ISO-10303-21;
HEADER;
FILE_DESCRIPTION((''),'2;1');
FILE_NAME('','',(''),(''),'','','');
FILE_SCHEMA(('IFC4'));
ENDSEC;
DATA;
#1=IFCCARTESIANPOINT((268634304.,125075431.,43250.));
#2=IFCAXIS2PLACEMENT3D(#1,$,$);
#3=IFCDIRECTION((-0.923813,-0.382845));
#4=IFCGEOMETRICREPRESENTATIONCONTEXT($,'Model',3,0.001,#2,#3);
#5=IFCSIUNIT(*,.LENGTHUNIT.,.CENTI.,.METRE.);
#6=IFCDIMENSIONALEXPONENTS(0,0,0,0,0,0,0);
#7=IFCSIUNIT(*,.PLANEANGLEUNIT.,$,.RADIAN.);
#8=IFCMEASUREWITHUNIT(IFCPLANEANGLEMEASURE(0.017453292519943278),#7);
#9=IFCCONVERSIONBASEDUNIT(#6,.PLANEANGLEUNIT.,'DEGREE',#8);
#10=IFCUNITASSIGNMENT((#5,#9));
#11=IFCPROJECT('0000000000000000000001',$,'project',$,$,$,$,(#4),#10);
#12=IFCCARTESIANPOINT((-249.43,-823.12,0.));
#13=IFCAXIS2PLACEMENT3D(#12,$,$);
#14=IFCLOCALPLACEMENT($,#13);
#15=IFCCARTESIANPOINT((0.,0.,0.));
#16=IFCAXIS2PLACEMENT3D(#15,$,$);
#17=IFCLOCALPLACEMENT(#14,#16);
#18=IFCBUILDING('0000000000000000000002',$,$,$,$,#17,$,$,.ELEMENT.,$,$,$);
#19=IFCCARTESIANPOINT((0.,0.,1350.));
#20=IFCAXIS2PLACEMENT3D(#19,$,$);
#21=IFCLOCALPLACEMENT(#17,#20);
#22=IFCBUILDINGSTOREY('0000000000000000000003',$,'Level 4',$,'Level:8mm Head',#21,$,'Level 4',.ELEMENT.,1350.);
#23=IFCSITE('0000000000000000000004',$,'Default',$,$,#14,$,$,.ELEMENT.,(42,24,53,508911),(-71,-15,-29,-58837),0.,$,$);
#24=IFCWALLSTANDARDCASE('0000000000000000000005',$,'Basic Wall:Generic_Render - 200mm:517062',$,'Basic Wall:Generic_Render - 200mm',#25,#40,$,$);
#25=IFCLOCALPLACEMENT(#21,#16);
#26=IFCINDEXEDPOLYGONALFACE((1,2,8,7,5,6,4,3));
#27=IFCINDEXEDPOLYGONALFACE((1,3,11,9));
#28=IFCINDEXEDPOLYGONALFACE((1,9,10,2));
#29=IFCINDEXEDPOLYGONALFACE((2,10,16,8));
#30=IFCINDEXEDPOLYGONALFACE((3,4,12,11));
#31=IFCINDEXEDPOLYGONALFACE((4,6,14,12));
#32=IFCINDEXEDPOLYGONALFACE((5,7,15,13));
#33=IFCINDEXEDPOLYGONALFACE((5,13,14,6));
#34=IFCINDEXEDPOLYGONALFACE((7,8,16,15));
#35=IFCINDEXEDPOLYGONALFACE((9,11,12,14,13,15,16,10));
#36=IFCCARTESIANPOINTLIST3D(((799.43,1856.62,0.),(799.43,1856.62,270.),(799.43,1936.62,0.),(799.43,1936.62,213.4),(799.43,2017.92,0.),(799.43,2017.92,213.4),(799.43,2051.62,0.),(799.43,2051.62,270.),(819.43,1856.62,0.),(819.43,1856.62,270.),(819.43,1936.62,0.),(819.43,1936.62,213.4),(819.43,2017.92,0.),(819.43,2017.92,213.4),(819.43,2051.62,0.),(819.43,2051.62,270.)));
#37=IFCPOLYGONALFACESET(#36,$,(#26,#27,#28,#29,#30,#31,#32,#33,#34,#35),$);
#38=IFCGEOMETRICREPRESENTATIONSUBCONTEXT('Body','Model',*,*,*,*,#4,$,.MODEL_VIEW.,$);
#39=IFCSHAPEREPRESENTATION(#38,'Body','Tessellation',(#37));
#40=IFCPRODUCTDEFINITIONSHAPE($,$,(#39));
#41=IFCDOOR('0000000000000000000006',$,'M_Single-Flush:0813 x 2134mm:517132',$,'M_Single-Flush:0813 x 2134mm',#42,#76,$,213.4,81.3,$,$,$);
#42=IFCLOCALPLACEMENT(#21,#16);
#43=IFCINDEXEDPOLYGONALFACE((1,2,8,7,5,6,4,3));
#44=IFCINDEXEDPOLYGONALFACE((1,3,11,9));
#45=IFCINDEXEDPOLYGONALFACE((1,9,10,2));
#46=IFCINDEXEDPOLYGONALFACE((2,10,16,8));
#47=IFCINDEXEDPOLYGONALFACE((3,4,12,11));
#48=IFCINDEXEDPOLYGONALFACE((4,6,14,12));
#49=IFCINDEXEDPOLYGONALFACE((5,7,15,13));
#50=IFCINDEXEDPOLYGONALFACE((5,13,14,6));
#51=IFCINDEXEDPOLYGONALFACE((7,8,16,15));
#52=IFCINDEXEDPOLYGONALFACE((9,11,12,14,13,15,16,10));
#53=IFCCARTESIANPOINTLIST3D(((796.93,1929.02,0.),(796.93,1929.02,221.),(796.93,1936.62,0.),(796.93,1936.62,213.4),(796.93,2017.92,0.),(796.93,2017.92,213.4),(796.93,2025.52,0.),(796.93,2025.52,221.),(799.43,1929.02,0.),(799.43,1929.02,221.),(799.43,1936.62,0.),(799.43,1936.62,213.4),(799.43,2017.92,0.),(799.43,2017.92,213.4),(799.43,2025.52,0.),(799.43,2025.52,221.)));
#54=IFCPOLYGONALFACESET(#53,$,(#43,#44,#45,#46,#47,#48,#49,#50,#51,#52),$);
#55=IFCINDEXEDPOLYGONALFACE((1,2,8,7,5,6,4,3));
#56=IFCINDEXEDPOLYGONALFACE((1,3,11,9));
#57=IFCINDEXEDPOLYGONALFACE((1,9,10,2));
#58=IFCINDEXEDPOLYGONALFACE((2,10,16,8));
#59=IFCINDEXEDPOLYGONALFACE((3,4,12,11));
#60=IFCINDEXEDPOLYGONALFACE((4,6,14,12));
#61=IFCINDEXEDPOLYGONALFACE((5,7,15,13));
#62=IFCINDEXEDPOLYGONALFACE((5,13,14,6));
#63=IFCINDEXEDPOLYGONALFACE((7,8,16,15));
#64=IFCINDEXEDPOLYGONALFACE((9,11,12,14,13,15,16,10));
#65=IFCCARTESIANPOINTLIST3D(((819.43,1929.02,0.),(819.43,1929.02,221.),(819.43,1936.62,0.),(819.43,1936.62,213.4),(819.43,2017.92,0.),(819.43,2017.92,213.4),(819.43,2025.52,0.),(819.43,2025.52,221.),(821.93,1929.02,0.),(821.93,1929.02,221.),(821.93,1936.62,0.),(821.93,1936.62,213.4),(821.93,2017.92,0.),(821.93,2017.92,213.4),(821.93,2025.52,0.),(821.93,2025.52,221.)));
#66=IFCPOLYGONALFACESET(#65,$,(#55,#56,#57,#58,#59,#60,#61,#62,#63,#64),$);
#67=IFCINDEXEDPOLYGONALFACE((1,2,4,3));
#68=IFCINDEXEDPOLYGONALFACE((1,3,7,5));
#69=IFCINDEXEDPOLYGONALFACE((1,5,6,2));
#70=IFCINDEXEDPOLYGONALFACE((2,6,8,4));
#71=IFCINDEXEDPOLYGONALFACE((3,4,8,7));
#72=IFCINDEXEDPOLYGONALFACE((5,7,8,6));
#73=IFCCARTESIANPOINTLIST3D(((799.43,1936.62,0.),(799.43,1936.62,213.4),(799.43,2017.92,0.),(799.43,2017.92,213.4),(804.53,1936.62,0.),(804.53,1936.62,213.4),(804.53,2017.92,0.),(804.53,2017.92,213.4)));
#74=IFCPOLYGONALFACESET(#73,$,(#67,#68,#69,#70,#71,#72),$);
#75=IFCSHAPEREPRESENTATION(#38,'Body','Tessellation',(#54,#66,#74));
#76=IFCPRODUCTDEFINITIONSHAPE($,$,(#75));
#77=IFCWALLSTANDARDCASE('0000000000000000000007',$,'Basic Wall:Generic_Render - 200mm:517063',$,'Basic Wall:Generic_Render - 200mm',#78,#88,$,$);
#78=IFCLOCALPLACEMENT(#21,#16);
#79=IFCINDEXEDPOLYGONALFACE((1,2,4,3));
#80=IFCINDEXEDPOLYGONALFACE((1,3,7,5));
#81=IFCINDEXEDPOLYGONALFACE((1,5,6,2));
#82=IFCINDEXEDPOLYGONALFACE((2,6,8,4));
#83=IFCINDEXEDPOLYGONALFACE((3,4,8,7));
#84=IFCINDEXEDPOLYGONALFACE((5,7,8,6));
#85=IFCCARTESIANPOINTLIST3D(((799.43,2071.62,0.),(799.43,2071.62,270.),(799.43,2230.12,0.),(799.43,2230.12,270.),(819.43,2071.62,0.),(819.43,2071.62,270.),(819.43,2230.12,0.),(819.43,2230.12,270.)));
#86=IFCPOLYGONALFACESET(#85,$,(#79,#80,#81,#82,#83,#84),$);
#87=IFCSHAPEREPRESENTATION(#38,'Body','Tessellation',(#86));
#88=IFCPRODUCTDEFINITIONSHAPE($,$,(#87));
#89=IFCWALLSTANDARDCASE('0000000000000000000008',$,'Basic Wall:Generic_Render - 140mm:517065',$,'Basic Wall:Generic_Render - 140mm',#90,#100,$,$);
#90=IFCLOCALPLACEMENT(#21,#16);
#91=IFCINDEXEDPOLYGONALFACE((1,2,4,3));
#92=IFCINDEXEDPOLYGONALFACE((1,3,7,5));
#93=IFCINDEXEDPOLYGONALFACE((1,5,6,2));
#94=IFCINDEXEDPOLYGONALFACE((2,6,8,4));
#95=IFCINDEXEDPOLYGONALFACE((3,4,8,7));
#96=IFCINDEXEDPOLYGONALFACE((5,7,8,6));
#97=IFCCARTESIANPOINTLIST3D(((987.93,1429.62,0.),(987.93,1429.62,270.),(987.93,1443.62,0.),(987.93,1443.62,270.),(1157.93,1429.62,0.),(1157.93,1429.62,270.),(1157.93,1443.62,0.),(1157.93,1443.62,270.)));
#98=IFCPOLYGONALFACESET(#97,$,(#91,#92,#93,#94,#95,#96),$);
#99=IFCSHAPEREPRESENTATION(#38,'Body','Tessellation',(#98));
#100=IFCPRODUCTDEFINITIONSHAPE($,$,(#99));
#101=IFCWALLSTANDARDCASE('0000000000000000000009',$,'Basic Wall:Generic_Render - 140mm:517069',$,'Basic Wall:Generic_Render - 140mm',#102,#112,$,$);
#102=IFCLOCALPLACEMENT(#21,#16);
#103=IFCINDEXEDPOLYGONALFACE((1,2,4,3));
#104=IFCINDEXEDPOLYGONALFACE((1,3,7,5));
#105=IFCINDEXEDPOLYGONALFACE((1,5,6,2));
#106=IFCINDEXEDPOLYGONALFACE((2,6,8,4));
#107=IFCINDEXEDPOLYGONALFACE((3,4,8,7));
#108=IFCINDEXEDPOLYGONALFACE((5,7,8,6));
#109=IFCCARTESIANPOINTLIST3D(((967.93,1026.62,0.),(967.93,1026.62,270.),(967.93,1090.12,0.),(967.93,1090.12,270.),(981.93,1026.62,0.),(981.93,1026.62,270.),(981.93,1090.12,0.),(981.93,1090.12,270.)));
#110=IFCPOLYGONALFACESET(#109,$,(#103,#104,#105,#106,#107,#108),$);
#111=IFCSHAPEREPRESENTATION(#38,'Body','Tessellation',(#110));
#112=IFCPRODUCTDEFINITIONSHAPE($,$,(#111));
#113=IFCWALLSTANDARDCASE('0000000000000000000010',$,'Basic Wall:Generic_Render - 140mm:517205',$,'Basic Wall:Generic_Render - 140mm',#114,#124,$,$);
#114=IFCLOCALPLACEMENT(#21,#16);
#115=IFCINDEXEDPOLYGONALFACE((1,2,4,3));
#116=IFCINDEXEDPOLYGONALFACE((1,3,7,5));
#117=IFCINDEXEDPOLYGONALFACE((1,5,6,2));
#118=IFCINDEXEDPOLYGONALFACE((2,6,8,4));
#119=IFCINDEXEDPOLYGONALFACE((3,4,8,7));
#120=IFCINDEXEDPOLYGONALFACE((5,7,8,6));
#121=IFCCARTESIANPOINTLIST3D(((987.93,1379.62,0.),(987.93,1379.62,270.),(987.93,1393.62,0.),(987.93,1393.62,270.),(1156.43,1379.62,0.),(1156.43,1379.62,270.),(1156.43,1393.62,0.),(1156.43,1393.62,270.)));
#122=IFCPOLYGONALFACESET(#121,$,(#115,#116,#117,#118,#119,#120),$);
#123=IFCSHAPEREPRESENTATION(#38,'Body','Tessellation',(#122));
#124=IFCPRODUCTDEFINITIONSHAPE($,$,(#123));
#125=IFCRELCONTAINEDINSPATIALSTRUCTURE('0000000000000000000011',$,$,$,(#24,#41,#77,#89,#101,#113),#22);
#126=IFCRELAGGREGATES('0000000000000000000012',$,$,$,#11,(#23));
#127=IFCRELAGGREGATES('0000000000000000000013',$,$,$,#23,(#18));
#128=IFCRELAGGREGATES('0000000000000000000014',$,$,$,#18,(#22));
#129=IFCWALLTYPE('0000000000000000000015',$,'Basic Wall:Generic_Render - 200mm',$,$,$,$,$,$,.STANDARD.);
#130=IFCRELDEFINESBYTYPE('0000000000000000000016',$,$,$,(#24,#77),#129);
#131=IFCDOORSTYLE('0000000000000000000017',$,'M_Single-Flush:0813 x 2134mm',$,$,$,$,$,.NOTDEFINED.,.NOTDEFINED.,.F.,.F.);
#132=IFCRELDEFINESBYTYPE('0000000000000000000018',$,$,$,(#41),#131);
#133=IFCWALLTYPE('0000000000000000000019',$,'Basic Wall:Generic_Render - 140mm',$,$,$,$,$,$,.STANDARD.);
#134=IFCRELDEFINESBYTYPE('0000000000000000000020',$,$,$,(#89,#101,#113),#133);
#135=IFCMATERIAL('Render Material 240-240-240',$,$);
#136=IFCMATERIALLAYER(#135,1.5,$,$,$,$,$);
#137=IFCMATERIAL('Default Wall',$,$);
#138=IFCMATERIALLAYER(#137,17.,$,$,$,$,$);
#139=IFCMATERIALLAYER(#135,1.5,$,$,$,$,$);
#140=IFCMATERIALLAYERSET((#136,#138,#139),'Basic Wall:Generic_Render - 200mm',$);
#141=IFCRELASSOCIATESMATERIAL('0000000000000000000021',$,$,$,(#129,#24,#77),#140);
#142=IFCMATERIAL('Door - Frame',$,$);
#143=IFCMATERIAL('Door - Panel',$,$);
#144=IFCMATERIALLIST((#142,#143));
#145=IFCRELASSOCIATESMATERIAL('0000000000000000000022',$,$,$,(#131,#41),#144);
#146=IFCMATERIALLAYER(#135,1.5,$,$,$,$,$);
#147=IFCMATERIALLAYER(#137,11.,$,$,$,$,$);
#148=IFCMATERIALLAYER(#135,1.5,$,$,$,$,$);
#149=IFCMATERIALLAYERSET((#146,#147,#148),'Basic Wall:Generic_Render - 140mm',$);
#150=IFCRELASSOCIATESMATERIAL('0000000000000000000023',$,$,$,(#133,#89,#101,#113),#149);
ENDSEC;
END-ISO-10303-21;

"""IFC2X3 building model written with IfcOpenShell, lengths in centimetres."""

from ifc_helpers import new_model, entity, si_unit, converted_unit, direction, frame, frame_2d, origin, place, context, subcontext, project, spatial, polyline, rectangle, outline, extrude, source, transform, mapped, material, material_list, layer, layer_set, layer_usage, type_object, type_shapes, element, fill, save


model = new_model("IFC2X3")

# Units and contexts
model_context = context("Model", 3, precision=0.001, world=frame((268634304.0, 125075431.0, 43250.0)), true_north=direction((-0.923813, -0.382845)))
body_context = subcontext(model_context, "Body", "Model", "MODEL_VIEW")
ifc_project = project(units=[si_unit("LENGTHUNIT", "METRE", prefix="CENTI"), converted_unit("PLANEANGLEUNIT", "DEGREE", entity("IfcPlaneAngleMeasure", 0.017453292519943278), si_unit("PLANEANGLEUNIT", "RADIAN"), dimensions=[0, 0, 0, 0, 0, 0, 0])], contexts=[model_context])

# Site, building, storey
site_placement = place(None, frame((-249.43, -823.12, 0.0)))
site = spatial("IfcSite", under=ifc_project, at=site_placement, Name="Default", CompositionType="ELEMENT", RefLatitude=(42, 24, 53, 508911), RefLongitude=(-71, -15, -29, -58837), RefElevation=0.0)
building_placement = place(site_placement, origin())
building = spatial("IfcBuilding", under=site, at=building_placement, CompositionType="ELEMENT")
storey_placement = place(building_placement, frame((0.0, 0.0, 1350.0)))
storey = spatial("IfcBuildingStorey", under=building, at=storey_placement, Name="Level 4", ObjectType="Level:8mm Head", LongName="Level 4", CompositionType="ELEMENT", Elevation=1350.0)

# Shared definitions
ifc_material_1 = material(Name="Render Material 240-240-240")
ifc_layer_1 = layer(ifc_material_1, 1.5)
ifc_material_2 = material(Name="Default Wall")
ifc_layer_2 = layer(ifc_material_2, 17.0)
ifc_layer_3 = layer(ifc_material_1, 1.5)
ifc_layer_set_1 = layer_set([ifc_layer_1, ifc_layer_2, ifc_layer_3], Name="Basic Wall:Generic_Render - 200mm")
wall_type_1 = type_object("IfcWallType", Name="Basic Wall:Generic_Render - 200mm", PredefinedType="STANDARD", material=ifc_layer_set_1)

# Wall, opening, door
ifc_layer_usage_1 = layer_usage(ifc_layer_set_1, "AXIS2", "NEGATIVE", 10.0)
wall_1_placement = place(storey_placement, frame((809.43, 1856.62, 0.0), z_axis=(0.0, 0.0, 1.0), x_axis=(0.0, 1.0, 0.0)))
wall_1 = element("IfcWallStandardCase", 1, at=wall_1_placement, inside=storey, type_object=wall_type_1, material=ifc_layer_usage_1, Name="Basic Wall:Generic_Render - 200mm:517062", ObjectType="Basic Wall:Generic_Render - 200mm", context=body_context, shape_type="SweptSolid", body=[
    extrude(rectangle(XDim=195.0, YDim=20.0, at=frame_2d((97.5, 0.0), x_axis=(-1.0, 0.0))), origin(), (0.0, 0.0, 1.0), 270.0),
])
opening_1_placement = place(wall_1_placement, frame((80.0, -10.0, 0.0)))
opening_1 = element("IfcOpeningElement", 2, at=opening_1_placement, cuts=wall_1, ObjectType="Opening", context=body_context, shape_type="SweptSolid", body=[
    extrude(rectangle(XDim=81.3, YDim=213.4, at=frame_2d((106.7, 40.65), x_axis=(0.0, 1.0))), frame((0.0, 0.0, 0.0), z_axis=(0.0, 1.0, 0.0), x_axis=(0.0, 0.0, 1.0)), (0.0, 0.0, 1.0), 20.0),
])
ifc_material_3 = material(Name="Door - Frame")
ifc_material_4 = material(Name="Door - Panel")
ifc_material_list_1 = material_list([ifc_material_3, ifc_material_4])
door_style = type_object("IfcDoorStyle", Name="M_Single-Flush:0813 x 2134mm", ConstructionType="NOTDEFINED", OperationType="NOTDEFINED", ParameterTakesPrecedence=False, Sizeable=False, material=ifc_material_list_1)
shared_shape_1 = source(origin(), body_context, "Body", "SweptSolid", [
    extrude(outline(polyline([(-48.25, -112.4), (48.25, -112.4), (48.25, 108.6), (40.65, 108.6), (40.65, -104.8), (-40.65, -104.8), (-40.65, 108.6), (-48.25, 108.6), (-48.25, -112.4)])), frame((40.65, 20.0, 108.6), z_axis=(0.0, 1.0, 0.0), x_axis=(1.0, 0.0, 0.0)), (0.0, 0.0, 1.0), 2.5),
    extrude(outline(polyline([(-112.4, -48.25), (108.6, -48.25), (108.6, -40.65), (-104.8, -40.65), (-104.8, 40.65), (108.6, 40.65), (108.6, 48.25), (-112.4, 48.25), (-112.4, -48.25)])), frame((40.65, -2.5, 108.6), z_axis=(0.0, 1.0, 0.0), x_axis=(0.0, 0.0, -1.0)), (0.0, 0.0, 1.0), 2.5),
    extrude(rectangle(XDim=5.1, YDim=81.3, at=frame_2d((0.0, 0.0), x_axis=(1.0, 0.0))), frame((40.65, 17.45, 0.0), z_axis=(0.0, 0.0, 1.0), x_axis=(0.0, 1.0, 0.0)), (0.0, 0.0, 1.0), 213.4),
])
type_shapes(door_style, [shared_shape_1])
door_placement = place(opening_1_placement, origin())
door = element("IfcDoor", 3, at=door_placement, inside=storey, type_object=door_style, material=ifc_material_list_1, Name="M_Single-Flush:0813 x 2134mm:517132", ObjectType="M_Single-Flush:0813 x 2134mm", OverallHeight=213.4, OverallWidth=81.3, context=body_context, shape_type="MappedRepresentation", body=[
    mapped(shared_shape_1, transform((0.0, 0.0, 0.0), scale=1.0)),
])
fill(opening_1, door)

# Walls
ifc_layer_usage_2 = layer_usage(ifc_layer_set_1, "AXIS2", "NEGATIVE", 10.0)
wall_2_placement = place(storey_placement, frame((809.43, 2071.62, 0.0), z_axis=(0.0, 0.0, 1.0), x_axis=(0.0, 1.0, 0.0)))
element("IfcWallStandardCase", 4, at=wall_2_placement, inside=storey, type_object=wall_type_1, material=ifc_layer_usage_2, Name="Basic Wall:Generic_Render - 200mm:517063", ObjectType="Basic Wall:Generic_Render - 200mm", context=body_context, shape_type="SweptSolid", body=[
    extrude(rectangle(XDim=158.5, YDim=20.0, at=frame_2d((79.25, 0.0), x_axis=(-1.0, 0.0))), origin(), (0.0, 0.0, 1.0), 270.0),
])
ifc_layer_4 = layer(ifc_material_1, 1.5)
ifc_layer_5 = layer(ifc_material_2, 11.0)
ifc_layer_6 = layer(ifc_material_1, 1.5)
ifc_layer_set_2 = layer_set([ifc_layer_4, ifc_layer_5, ifc_layer_6], Name="Basic Wall:Generic_Render - 140mm")
ifc_layer_usage_3 = layer_usage(ifc_layer_set_2, "AXIS2", "NEGATIVE", 7.0)
wall_type_2 = type_object("IfcWallType", Name="Basic Wall:Generic_Render - 140mm", PredefinedType="STANDARD", material=ifc_layer_set_2)
wall_3_placement = place(storey_placement, frame((1157.93, 1436.62, 0.0), z_axis=(0.0, 0.0, 1.0), x_axis=(-1.0, 0.0, 0.0)))
element("IfcWallStandardCase", 5, at=wall_3_placement, inside=storey, type_object=wall_type_2, material=ifc_layer_usage_3, Name="Basic Wall:Generic_Render - 140mm:517065", ObjectType="Basic Wall:Generic_Render - 140mm", context=body_context, shape_type="SweptSolid", body=[
    extrude(rectangle(XDim=170.0, YDim=14.0, at=frame_2d((85.0, 0.0), x_axis=(-1.0, 0.0))), origin(), (0.0, 0.0, 1.0), 270.0),
])
ifc_layer_usage_4 = layer_usage(ifc_layer_set_2, "AXIS2", "NEGATIVE", 7.0)
wall_4_placement = place(storey_placement, frame((974.93, 1090.12, 0.0), z_axis=(0.0, 0.0, 1.0), x_axis=(0.0, -1.0, 0.0)))
element("IfcWallStandardCase", 6, at=wall_4_placement, inside=storey, type_object=wall_type_2, material=ifc_layer_usage_4, Name="Basic Wall:Generic_Render - 140mm:517069", ObjectType="Basic Wall:Generic_Render - 140mm", context=body_context, shape_type="SweptSolid", body=[
    extrude(rectangle(XDim=63.5, YDim=14.0, at=frame_2d((31.75, 0.0), x_axis=(-1.0, 0.0))), origin(), (0.0, 0.0, 1.0), 270.0),
])
ifc_layer_usage_5 = layer_usage(ifc_layer_set_2, "AXIS2", "NEGATIVE", 7.0)
wall_5_placement = place(storey_placement, frame((1156.43, 1386.62, 0.0), z_axis=(0.0, 0.0, 1.0), x_axis=(-1.0, 0.0, 0.0)))
element("IfcWallStandardCase", 7, at=wall_5_placement, inside=storey, type_object=wall_type_2, material=ifc_layer_usage_5, Name="Basic Wall:Generic_Render - 140mm:517205", ObjectType="Basic Wall:Generic_Render - 140mm", context=body_context, shape_type="SweptSolid", body=[
    extrude(rectangle(XDim=168.5, YDim=14.0, at=frame_2d((84.25, 0.0), x_axis=(-1.0, 0.0))), origin(), (0.0, 0.0, 1.0), 270.0),
])

save(model, "model.ifc")
